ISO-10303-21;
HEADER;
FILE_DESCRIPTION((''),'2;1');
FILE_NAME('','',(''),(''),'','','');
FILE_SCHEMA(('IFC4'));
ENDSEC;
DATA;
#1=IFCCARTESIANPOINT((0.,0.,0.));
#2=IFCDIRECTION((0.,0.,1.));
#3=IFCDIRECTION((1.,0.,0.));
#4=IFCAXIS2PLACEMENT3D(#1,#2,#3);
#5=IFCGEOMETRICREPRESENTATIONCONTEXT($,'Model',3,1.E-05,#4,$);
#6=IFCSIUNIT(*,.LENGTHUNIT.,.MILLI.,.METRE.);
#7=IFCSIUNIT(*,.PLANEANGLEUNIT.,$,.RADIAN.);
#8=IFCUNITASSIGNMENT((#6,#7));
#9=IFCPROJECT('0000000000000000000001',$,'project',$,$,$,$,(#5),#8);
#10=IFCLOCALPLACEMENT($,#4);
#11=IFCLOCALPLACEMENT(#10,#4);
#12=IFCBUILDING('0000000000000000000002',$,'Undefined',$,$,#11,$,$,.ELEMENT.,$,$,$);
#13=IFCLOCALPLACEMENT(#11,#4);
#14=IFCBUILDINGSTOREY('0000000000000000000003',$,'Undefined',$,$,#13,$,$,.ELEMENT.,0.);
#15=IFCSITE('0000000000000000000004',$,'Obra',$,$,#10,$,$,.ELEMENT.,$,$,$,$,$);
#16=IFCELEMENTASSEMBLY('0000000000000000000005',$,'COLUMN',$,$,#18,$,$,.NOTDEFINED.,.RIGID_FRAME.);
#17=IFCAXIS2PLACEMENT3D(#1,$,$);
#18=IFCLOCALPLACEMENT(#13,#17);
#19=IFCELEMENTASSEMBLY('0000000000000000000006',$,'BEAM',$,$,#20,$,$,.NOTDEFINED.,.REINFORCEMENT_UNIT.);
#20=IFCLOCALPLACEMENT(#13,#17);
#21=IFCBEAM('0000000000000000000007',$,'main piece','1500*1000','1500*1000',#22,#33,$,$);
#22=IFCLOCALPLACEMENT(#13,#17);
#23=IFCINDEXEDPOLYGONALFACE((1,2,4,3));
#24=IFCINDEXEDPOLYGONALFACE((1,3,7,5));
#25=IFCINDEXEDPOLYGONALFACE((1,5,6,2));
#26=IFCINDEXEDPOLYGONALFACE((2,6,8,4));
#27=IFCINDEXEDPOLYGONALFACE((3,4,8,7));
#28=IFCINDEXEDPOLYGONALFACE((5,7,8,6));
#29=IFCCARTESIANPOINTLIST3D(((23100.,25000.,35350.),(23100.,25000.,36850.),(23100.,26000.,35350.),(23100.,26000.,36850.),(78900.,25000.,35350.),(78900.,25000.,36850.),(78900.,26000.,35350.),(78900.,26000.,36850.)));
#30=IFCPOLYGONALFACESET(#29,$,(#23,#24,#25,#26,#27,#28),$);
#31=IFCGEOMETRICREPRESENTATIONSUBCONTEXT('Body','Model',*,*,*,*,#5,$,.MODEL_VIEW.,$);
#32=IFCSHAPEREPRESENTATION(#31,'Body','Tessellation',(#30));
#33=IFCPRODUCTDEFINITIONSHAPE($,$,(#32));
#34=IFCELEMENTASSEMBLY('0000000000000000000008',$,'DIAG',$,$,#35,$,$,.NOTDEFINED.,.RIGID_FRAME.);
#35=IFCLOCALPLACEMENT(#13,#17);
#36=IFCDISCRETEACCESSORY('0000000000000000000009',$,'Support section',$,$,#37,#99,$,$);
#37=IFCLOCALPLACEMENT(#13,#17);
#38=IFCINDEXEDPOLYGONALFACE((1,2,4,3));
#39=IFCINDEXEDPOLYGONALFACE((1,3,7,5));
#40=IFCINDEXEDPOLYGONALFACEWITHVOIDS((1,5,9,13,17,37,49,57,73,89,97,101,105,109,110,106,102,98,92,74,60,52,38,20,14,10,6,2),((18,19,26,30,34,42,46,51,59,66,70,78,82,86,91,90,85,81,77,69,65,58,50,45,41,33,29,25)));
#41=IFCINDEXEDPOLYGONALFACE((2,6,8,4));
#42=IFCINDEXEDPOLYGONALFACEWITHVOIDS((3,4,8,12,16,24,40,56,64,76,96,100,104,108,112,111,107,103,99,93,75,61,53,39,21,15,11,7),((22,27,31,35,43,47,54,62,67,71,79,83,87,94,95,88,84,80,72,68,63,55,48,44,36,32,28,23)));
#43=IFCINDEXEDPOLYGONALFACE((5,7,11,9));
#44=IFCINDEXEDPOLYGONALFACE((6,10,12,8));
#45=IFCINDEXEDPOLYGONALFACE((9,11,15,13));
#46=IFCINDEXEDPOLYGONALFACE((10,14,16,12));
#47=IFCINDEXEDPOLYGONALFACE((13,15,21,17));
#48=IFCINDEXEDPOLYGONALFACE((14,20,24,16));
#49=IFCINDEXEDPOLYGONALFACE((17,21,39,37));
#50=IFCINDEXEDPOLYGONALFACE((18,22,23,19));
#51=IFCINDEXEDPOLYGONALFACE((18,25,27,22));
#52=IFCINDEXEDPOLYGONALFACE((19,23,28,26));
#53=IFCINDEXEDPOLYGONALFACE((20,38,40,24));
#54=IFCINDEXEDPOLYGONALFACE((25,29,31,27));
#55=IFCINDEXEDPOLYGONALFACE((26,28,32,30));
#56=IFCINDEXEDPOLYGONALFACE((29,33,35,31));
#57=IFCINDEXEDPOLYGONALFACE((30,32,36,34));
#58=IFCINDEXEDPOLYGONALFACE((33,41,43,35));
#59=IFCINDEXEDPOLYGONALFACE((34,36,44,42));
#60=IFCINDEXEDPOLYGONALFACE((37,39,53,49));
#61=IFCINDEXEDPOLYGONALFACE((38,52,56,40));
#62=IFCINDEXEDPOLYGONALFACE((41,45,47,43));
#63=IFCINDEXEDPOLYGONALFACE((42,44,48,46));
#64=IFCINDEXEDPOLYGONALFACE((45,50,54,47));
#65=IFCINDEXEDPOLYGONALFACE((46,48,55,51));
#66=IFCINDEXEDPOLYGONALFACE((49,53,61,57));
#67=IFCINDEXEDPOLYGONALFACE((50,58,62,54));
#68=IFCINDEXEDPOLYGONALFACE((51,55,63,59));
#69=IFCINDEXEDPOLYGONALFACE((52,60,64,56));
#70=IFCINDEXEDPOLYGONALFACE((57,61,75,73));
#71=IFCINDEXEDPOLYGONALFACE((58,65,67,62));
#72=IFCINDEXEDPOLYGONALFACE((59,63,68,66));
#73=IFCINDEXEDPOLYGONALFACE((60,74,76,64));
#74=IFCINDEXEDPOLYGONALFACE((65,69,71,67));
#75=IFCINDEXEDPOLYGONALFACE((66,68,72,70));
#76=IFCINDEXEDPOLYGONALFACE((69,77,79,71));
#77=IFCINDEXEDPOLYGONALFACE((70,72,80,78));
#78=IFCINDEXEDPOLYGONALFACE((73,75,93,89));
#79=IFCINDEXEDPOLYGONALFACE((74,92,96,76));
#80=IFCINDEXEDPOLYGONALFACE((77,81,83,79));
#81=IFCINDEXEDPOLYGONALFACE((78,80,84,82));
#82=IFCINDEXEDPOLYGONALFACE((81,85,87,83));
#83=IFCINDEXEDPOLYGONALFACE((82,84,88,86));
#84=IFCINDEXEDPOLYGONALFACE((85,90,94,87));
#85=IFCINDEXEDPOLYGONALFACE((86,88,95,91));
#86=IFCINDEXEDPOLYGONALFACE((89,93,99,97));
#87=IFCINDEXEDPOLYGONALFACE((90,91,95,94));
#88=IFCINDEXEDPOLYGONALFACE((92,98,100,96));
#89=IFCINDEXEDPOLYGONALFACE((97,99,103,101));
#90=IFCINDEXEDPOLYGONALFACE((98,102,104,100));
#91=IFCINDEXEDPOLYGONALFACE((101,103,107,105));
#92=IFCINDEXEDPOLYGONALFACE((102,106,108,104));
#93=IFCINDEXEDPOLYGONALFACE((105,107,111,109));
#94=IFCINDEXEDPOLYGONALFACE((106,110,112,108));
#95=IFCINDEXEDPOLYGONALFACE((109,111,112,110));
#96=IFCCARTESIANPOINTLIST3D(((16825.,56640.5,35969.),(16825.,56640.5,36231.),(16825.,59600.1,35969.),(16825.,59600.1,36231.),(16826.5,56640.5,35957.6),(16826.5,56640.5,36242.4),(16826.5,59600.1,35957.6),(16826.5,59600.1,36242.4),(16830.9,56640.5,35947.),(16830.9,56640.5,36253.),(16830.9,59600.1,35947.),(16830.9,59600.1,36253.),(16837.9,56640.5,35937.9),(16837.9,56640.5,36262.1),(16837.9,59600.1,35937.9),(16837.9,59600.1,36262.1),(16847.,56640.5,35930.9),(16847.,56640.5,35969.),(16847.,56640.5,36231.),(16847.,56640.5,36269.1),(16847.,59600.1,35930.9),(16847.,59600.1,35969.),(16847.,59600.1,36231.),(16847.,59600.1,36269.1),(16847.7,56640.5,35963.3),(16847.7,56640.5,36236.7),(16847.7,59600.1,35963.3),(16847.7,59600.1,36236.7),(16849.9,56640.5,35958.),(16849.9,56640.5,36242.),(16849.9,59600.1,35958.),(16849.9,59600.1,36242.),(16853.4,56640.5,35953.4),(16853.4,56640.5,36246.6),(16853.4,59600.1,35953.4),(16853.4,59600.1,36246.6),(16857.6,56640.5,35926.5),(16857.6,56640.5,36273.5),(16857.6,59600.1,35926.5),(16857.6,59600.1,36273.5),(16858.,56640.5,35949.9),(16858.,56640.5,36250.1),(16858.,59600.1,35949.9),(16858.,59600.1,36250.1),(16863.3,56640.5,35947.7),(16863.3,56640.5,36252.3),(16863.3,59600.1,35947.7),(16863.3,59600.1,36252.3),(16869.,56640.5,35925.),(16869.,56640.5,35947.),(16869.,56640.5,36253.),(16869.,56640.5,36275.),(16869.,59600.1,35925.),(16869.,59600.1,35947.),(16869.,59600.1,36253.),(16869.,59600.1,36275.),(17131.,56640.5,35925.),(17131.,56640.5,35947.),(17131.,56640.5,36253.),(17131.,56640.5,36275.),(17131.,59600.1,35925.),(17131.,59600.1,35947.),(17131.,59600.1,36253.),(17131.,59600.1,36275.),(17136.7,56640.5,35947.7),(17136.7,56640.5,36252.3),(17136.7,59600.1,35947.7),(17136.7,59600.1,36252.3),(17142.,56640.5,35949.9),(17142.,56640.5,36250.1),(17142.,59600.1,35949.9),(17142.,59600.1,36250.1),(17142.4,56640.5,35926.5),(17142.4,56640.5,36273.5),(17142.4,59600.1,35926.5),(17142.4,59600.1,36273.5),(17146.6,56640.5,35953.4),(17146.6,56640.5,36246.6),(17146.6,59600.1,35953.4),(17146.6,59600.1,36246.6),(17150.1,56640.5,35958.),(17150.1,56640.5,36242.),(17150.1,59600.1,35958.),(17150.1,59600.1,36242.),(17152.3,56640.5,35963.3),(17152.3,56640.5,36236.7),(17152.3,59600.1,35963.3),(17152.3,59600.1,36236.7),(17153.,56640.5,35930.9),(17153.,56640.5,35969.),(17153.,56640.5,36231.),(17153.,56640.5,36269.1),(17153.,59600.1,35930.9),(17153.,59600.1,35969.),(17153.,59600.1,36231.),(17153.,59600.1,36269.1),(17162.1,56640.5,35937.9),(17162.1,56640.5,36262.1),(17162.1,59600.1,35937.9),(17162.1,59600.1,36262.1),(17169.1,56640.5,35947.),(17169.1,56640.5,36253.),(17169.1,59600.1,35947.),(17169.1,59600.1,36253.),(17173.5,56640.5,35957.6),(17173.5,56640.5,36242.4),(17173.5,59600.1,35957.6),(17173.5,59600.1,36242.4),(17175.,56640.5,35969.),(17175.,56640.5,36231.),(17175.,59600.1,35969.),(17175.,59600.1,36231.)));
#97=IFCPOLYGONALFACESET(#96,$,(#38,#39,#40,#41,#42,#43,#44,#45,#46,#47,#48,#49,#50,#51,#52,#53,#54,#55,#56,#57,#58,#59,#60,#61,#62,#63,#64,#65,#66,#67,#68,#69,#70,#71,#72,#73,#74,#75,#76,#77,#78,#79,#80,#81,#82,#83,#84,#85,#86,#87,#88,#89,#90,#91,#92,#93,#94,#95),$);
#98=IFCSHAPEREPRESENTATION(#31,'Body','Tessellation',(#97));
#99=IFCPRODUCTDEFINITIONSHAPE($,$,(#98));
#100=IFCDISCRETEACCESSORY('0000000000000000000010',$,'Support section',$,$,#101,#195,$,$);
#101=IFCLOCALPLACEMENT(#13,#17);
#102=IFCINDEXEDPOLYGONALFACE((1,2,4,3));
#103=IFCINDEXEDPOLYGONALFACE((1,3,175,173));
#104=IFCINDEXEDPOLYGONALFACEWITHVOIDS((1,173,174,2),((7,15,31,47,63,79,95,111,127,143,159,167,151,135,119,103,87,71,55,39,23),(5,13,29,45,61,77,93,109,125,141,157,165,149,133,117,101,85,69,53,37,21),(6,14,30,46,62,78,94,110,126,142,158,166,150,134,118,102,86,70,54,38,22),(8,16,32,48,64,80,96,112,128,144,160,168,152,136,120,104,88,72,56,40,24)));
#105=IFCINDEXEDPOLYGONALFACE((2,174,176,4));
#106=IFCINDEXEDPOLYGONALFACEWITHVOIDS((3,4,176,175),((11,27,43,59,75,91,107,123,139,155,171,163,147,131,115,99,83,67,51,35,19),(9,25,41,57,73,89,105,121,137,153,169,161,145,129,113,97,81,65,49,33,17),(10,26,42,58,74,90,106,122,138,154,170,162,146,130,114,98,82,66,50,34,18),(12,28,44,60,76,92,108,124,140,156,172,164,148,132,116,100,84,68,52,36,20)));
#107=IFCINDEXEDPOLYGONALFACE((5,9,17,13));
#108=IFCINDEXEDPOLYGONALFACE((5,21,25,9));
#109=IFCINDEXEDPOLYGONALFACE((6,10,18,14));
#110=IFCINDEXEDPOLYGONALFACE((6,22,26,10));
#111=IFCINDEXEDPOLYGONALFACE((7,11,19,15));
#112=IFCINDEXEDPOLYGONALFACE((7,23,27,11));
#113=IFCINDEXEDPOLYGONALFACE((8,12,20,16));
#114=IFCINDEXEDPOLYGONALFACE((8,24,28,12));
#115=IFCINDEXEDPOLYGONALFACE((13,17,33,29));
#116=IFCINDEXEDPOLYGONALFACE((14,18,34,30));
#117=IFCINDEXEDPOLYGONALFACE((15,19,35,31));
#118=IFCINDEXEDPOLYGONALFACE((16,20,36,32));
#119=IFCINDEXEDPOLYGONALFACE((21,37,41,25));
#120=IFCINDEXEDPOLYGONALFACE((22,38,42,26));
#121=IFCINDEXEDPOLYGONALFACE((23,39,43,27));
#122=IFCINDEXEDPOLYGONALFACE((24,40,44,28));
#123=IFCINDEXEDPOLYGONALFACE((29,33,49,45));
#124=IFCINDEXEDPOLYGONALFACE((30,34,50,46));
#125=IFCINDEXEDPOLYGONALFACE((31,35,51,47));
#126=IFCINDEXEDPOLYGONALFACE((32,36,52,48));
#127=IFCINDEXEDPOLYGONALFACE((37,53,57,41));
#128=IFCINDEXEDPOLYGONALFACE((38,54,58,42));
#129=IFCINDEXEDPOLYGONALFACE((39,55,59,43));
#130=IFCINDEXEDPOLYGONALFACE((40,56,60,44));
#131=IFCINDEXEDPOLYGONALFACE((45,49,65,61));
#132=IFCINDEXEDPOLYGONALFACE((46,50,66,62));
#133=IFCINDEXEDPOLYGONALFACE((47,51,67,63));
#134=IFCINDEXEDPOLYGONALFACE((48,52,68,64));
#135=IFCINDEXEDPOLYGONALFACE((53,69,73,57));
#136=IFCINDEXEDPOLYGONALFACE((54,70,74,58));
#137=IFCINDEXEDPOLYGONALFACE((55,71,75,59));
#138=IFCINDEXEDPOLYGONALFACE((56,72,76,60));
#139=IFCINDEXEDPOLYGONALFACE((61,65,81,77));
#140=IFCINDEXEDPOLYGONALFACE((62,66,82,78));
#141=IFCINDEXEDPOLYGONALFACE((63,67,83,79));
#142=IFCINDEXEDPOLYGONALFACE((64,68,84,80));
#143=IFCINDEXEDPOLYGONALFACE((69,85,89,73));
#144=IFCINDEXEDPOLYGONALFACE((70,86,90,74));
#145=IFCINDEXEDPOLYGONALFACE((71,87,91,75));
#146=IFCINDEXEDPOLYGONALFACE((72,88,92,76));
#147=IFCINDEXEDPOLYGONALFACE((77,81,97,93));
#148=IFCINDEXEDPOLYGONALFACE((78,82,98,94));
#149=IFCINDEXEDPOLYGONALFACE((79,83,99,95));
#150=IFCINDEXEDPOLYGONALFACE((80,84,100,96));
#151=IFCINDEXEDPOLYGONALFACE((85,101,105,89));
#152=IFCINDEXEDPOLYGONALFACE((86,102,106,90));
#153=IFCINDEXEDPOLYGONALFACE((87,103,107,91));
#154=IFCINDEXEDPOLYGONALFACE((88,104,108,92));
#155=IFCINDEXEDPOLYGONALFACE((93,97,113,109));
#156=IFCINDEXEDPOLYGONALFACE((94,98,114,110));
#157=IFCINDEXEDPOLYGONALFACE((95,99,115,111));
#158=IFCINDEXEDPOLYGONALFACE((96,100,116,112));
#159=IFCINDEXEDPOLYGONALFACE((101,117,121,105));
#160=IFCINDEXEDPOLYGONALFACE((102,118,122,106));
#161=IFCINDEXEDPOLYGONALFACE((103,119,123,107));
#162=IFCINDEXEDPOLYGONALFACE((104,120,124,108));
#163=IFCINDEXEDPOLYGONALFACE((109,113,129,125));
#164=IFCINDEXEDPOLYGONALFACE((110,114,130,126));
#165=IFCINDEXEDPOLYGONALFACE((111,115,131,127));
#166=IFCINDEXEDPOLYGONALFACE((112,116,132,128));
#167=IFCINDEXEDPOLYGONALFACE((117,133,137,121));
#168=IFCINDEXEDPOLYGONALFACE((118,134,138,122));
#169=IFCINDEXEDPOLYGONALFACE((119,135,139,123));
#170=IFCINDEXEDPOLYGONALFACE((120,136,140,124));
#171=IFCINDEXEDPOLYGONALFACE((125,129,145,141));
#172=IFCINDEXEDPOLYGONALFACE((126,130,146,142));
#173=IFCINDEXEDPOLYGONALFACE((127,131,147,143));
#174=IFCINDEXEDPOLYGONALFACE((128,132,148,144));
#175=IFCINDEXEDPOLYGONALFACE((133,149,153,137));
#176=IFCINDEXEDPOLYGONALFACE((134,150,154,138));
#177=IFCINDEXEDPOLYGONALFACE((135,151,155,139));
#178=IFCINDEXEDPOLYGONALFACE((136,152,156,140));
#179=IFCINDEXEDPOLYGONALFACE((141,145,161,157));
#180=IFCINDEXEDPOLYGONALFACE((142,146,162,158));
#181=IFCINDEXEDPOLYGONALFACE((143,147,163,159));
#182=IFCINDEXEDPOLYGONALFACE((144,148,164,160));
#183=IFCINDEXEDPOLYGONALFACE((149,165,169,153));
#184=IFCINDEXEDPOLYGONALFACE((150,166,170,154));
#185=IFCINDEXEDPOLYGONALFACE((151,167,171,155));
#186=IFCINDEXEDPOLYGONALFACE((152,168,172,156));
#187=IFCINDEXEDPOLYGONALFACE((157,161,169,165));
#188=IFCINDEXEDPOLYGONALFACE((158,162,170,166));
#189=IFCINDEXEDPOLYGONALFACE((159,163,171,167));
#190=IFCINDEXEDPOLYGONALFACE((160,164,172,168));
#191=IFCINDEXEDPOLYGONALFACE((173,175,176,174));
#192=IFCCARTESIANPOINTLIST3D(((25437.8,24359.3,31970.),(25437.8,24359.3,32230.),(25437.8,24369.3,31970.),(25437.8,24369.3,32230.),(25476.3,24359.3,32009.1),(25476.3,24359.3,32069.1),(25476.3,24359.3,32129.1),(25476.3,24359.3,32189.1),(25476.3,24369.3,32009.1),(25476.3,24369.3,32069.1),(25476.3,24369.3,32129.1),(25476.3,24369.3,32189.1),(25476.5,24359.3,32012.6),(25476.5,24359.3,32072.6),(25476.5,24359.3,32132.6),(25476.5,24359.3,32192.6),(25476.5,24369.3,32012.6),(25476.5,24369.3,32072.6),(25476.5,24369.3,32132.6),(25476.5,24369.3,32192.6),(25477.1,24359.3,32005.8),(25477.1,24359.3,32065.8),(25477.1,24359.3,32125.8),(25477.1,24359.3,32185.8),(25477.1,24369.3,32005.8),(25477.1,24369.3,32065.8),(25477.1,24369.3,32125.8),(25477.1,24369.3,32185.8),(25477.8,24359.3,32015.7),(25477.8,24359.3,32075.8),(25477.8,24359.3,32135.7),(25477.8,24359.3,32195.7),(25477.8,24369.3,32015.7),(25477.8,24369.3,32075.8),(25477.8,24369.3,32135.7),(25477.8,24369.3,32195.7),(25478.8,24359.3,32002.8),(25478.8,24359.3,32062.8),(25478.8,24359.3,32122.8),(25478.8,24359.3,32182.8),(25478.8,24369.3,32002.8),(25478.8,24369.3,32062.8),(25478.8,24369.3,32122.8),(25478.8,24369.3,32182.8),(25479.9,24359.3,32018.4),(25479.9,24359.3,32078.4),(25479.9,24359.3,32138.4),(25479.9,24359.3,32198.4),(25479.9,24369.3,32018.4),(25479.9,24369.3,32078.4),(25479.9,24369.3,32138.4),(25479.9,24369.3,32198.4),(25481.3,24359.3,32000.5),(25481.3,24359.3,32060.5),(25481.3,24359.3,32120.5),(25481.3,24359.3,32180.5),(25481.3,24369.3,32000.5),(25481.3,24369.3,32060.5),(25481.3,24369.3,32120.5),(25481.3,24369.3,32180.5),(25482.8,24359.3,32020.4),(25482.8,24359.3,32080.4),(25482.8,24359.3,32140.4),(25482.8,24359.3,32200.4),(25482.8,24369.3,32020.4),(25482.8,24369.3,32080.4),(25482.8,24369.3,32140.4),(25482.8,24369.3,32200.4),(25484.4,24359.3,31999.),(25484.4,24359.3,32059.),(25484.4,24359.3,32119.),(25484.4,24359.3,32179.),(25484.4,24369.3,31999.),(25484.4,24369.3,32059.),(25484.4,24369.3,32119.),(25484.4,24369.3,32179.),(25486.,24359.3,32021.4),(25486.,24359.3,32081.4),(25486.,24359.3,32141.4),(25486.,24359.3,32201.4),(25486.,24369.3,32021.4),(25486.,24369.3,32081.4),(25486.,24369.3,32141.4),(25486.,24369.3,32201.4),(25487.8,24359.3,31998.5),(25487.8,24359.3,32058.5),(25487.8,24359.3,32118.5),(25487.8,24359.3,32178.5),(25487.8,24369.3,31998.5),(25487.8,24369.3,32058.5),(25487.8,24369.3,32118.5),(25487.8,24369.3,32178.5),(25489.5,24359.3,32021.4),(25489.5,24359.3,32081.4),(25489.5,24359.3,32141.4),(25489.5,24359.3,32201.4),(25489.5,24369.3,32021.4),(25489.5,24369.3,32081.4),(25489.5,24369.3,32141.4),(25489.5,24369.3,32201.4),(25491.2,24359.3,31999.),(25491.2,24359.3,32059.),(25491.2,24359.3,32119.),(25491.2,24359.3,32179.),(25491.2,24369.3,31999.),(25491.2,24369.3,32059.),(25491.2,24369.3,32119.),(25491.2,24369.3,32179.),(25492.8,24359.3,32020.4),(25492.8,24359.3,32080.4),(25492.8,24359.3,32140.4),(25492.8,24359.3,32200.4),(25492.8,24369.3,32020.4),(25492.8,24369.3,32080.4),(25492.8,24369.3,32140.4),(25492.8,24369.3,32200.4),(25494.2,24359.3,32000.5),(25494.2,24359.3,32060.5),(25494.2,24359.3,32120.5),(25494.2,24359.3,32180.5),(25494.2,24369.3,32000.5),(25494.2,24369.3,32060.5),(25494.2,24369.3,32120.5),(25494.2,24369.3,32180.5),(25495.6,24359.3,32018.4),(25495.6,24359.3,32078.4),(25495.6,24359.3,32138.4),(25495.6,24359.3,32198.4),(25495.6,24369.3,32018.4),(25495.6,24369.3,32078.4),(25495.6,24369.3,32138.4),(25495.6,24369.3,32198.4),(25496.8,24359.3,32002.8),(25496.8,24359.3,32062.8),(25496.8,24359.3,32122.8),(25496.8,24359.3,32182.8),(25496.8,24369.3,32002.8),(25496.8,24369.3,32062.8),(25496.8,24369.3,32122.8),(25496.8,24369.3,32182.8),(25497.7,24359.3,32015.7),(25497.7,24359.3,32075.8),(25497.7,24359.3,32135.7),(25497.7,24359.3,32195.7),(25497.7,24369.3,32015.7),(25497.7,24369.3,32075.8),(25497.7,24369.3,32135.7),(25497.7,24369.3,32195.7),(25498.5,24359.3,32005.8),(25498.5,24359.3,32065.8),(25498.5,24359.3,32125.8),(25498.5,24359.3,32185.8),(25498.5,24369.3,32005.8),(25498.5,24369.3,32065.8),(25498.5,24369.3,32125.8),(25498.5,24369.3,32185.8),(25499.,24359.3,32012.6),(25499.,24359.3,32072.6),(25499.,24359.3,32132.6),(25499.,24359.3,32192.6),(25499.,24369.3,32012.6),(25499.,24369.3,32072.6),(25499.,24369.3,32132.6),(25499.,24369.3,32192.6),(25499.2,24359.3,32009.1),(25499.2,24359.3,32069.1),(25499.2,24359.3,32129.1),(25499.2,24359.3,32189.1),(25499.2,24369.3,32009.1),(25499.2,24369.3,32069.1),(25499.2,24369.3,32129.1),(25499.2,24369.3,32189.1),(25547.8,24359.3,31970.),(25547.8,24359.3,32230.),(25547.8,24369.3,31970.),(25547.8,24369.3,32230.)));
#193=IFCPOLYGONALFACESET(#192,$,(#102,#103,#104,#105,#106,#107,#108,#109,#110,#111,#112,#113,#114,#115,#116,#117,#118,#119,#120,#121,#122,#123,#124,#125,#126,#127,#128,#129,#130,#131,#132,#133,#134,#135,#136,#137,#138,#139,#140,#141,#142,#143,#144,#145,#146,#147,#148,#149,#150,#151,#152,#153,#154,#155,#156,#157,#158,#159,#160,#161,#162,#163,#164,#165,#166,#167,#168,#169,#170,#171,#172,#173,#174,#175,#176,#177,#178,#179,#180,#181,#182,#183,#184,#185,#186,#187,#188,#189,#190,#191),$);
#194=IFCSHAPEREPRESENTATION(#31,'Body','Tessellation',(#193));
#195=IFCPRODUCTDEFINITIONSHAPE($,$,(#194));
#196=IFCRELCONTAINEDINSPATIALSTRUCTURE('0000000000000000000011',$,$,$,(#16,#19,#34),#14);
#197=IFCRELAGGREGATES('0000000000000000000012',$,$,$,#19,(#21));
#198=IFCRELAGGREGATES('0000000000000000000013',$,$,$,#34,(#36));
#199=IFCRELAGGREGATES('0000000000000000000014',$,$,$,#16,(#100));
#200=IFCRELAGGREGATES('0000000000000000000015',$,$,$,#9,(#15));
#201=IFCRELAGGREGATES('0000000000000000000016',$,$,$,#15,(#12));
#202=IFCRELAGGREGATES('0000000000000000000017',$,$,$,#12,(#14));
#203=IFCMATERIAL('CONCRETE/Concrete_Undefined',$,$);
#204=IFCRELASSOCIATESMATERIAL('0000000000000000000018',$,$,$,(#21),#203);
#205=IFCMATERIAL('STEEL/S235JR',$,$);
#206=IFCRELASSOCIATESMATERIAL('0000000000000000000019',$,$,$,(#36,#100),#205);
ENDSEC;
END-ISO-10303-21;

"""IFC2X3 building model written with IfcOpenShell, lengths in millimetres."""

from ifc_helpers import new_model, si_unit, frame, origin_with_axes, origin_2d_with_axis, place, context, subcontext, project, spatial, rectangle, hollow_rectangle, circle, extrude, clip, halfspace, source, transform, mapped, material, element, aggregate, save


model = new_model("IFC2X3")

# Units and contexts
model_context = context("Model", 3, precision=1e-05, world=origin_with_axes())
body_context = subcontext(model_context, "Body", "Model", "MODEL_VIEW")
ifc_project = project(units=[si_unit("LENGTHUNIT", "METRE", prefix="MILLI"), si_unit("PLANEANGLEUNIT", "RADIAN")], contexts=[model_context])

# Site, building, storey
site_placement = place(None, origin_with_axes())
site = spatial("IfcSite", under=ifc_project, at=site_placement, Name="Obra", CompositionType="ELEMENT")
building_placement = place(site_placement, origin_with_axes())
building = spatial("IfcBuilding", under=site, at=building_placement, Name="Undefined", CompositionType="ELEMENT")
storey_placement = place(building_placement, origin_with_axes())
storey = spatial("IfcBuildingStorey", under=building, at=storey_placement, Name="Undefined", CompositionType="ELEMENT", Elevation=0.0)

# Element assembly
ifc_material_1 = material(Name="STEEL/S235JR")
assembly_1_placement = place(storey_placement, origin_with_axes())
assembly_1 = element("IfcElementAssembly", 1, at=assembly_1_placement, inside=storey, Name="COLUMN", AssemblyPlace="NOTDEFINED", PredefinedType="RIGID_FRAME")

# Element assembly, beam
ifc_material_2 = material(Name="CONCRETE/Concrete_Undefined")
assembly_2_placement = place(storey_placement, origin_with_axes())
assembly_2 = element("IfcElementAssembly", 2, at=assembly_2_placement, inside=storey, Name="BEAM", AssemblyPlace="NOTDEFINED", PredefinedType="REINFORCEMENT_UNIT")
beam_1_placement = place(assembly_2_placement, frame((23100.0, 25500.0, 36100.0), z_axis=(0.0, 0.0, 1.0), x_axis=(1.0, 0.0, 0.0)))
beam_1 = element("IfcBeam", 3, at=beam_1_placement, material=ifc_material_2, Name="main piece", Description="1500*1000", ObjectType="1500*1000", context=body_context, shape_type="SweptSolid", body=[
    extrude(rectangle(XDim=1000.0, YDim=1500.0, at=origin_2d_with_axis()), frame((55800.0, 0.0, 0.0), z_axis=(-1.0, 0.0, 0.0), x_axis=(0.0, -1.0, 0.0)), (0.0, 0.0, 1.0), 55800.0),
])
aggregate(assembly_2, [beam_1])

# Element assembly
assembly_3_placement = place(storey_placement, origin_with_axes())
assembly_3 = element("IfcElementAssembly", 4, at=assembly_3_placement, inside=storey, Name="DIAG", AssemblyPlace="NOTDEFINED", PredefinedType="RIGID_FRAME")

# Discrete accessory
discrete_accessory_1_placement = place(assembly_3_placement, frame((17000.0, 56620.1, 36100.0), z_axis=(0.0, 0.0, 1.0), x_axis=(0.0, 1.0, 0.0)))
discrete_accessory_1 = element("IfcDiscreteAccessory", 5, at=discrete_accessory_1_placement, material=ifc_material_1, Name="Support section", context=body_context, shape_type="Clipping", body=[
    clip(clip(extrude(hollow_rectangle(XDim=350.0, YDim=350.0, WallThickness=22.0, InnerFilletRadius=22.0, OuterFilletRadius=44.0, at=origin_2d_with_axis()), frame((2980.0, 0.0, 0.0), z_axis=(-1.0, 0.0, 0.0), x_axis=(0.0, -1.0, 0.0)), (0.0, 0.0, 1.0), 2959.6), halfspace(frame((2979.9, 0.0, -1000.0), z_axis=(-1.0, 0.0, 0.000056), x_axis=(0.0, 1.0, 0.0)), True)), halfspace(frame((20.4, 0.0, -175.0), z_axis=(1.0, 0.0, -0.000038), x_axis=(0.0, -1.0, 0.0)), True)),
])
aggregate(assembly_3, [discrete_accessory_1])

# Discrete accessory, opening
discrete_accessory_2_placement = place(assembly_1_placement, frame((25492.8, 24364.3, 31970.0), z_axis=(0.0, 0.0, 1.0), x_axis=(1.0, 0.0, 0.0)))
discrete_accessory_2 = element("IfcDiscreteAccessory", 6, at=discrete_accessory_2_placement, material=ifc_material_1, Name="Support section", context=body_context, shape_type="SweptSolid", body=[
    extrude(rectangle(XDim=10.0, YDim=110.0, at=origin_2d_with_axis()), frame((0.0, 0.0, 260.0), z_axis=(0.0, 0.0, -1.0), x_axis=(0.0, 1.0, 0.0)), (0.0, 0.0, 1.0), 260.0),
])
shared_shape_1 = source(origin_with_axes(), body_context, "Body", "SweptSolid", [
    extrude(circle(Radius=11.5, at=origin_2d_with_axis()), frame((0.0, -14.4, 0.0), z_axis=(0.0, 1.0, 0.0), x_axis=(1.0, 0.0, 0.0)), (0.0, 0.0, 1.0), 10.2),
])
opening_1_placement = place(assembly_1_placement, frame((25537.8, 24355.0, 32300.0), z_axis=(-1.0, 0.0, 0.0), x_axis=(0.0, 0.0, -1.0)))
element("IfcOpeningElement", 7, at=opening_1_placement, cuts=discrete_accessory_2, ObjectType="Opening", context=body_context, shape_type="MappedRepresentation", body=[
    mapped(shared_shape_1, transform((110.0, 0.0, 50.0))),
    mapped(shared_shape_1, transform((170.0, 0.0, 50.0))),
    mapped(shared_shape_1, transform((230.0, 0.0, 50.0))),
    mapped(shared_shape_1, transform((290.0, 0.0, 50.0))),
])

aggregate(assembly_1, [discrete_accessory_2])

save(model, "model.ifc")
